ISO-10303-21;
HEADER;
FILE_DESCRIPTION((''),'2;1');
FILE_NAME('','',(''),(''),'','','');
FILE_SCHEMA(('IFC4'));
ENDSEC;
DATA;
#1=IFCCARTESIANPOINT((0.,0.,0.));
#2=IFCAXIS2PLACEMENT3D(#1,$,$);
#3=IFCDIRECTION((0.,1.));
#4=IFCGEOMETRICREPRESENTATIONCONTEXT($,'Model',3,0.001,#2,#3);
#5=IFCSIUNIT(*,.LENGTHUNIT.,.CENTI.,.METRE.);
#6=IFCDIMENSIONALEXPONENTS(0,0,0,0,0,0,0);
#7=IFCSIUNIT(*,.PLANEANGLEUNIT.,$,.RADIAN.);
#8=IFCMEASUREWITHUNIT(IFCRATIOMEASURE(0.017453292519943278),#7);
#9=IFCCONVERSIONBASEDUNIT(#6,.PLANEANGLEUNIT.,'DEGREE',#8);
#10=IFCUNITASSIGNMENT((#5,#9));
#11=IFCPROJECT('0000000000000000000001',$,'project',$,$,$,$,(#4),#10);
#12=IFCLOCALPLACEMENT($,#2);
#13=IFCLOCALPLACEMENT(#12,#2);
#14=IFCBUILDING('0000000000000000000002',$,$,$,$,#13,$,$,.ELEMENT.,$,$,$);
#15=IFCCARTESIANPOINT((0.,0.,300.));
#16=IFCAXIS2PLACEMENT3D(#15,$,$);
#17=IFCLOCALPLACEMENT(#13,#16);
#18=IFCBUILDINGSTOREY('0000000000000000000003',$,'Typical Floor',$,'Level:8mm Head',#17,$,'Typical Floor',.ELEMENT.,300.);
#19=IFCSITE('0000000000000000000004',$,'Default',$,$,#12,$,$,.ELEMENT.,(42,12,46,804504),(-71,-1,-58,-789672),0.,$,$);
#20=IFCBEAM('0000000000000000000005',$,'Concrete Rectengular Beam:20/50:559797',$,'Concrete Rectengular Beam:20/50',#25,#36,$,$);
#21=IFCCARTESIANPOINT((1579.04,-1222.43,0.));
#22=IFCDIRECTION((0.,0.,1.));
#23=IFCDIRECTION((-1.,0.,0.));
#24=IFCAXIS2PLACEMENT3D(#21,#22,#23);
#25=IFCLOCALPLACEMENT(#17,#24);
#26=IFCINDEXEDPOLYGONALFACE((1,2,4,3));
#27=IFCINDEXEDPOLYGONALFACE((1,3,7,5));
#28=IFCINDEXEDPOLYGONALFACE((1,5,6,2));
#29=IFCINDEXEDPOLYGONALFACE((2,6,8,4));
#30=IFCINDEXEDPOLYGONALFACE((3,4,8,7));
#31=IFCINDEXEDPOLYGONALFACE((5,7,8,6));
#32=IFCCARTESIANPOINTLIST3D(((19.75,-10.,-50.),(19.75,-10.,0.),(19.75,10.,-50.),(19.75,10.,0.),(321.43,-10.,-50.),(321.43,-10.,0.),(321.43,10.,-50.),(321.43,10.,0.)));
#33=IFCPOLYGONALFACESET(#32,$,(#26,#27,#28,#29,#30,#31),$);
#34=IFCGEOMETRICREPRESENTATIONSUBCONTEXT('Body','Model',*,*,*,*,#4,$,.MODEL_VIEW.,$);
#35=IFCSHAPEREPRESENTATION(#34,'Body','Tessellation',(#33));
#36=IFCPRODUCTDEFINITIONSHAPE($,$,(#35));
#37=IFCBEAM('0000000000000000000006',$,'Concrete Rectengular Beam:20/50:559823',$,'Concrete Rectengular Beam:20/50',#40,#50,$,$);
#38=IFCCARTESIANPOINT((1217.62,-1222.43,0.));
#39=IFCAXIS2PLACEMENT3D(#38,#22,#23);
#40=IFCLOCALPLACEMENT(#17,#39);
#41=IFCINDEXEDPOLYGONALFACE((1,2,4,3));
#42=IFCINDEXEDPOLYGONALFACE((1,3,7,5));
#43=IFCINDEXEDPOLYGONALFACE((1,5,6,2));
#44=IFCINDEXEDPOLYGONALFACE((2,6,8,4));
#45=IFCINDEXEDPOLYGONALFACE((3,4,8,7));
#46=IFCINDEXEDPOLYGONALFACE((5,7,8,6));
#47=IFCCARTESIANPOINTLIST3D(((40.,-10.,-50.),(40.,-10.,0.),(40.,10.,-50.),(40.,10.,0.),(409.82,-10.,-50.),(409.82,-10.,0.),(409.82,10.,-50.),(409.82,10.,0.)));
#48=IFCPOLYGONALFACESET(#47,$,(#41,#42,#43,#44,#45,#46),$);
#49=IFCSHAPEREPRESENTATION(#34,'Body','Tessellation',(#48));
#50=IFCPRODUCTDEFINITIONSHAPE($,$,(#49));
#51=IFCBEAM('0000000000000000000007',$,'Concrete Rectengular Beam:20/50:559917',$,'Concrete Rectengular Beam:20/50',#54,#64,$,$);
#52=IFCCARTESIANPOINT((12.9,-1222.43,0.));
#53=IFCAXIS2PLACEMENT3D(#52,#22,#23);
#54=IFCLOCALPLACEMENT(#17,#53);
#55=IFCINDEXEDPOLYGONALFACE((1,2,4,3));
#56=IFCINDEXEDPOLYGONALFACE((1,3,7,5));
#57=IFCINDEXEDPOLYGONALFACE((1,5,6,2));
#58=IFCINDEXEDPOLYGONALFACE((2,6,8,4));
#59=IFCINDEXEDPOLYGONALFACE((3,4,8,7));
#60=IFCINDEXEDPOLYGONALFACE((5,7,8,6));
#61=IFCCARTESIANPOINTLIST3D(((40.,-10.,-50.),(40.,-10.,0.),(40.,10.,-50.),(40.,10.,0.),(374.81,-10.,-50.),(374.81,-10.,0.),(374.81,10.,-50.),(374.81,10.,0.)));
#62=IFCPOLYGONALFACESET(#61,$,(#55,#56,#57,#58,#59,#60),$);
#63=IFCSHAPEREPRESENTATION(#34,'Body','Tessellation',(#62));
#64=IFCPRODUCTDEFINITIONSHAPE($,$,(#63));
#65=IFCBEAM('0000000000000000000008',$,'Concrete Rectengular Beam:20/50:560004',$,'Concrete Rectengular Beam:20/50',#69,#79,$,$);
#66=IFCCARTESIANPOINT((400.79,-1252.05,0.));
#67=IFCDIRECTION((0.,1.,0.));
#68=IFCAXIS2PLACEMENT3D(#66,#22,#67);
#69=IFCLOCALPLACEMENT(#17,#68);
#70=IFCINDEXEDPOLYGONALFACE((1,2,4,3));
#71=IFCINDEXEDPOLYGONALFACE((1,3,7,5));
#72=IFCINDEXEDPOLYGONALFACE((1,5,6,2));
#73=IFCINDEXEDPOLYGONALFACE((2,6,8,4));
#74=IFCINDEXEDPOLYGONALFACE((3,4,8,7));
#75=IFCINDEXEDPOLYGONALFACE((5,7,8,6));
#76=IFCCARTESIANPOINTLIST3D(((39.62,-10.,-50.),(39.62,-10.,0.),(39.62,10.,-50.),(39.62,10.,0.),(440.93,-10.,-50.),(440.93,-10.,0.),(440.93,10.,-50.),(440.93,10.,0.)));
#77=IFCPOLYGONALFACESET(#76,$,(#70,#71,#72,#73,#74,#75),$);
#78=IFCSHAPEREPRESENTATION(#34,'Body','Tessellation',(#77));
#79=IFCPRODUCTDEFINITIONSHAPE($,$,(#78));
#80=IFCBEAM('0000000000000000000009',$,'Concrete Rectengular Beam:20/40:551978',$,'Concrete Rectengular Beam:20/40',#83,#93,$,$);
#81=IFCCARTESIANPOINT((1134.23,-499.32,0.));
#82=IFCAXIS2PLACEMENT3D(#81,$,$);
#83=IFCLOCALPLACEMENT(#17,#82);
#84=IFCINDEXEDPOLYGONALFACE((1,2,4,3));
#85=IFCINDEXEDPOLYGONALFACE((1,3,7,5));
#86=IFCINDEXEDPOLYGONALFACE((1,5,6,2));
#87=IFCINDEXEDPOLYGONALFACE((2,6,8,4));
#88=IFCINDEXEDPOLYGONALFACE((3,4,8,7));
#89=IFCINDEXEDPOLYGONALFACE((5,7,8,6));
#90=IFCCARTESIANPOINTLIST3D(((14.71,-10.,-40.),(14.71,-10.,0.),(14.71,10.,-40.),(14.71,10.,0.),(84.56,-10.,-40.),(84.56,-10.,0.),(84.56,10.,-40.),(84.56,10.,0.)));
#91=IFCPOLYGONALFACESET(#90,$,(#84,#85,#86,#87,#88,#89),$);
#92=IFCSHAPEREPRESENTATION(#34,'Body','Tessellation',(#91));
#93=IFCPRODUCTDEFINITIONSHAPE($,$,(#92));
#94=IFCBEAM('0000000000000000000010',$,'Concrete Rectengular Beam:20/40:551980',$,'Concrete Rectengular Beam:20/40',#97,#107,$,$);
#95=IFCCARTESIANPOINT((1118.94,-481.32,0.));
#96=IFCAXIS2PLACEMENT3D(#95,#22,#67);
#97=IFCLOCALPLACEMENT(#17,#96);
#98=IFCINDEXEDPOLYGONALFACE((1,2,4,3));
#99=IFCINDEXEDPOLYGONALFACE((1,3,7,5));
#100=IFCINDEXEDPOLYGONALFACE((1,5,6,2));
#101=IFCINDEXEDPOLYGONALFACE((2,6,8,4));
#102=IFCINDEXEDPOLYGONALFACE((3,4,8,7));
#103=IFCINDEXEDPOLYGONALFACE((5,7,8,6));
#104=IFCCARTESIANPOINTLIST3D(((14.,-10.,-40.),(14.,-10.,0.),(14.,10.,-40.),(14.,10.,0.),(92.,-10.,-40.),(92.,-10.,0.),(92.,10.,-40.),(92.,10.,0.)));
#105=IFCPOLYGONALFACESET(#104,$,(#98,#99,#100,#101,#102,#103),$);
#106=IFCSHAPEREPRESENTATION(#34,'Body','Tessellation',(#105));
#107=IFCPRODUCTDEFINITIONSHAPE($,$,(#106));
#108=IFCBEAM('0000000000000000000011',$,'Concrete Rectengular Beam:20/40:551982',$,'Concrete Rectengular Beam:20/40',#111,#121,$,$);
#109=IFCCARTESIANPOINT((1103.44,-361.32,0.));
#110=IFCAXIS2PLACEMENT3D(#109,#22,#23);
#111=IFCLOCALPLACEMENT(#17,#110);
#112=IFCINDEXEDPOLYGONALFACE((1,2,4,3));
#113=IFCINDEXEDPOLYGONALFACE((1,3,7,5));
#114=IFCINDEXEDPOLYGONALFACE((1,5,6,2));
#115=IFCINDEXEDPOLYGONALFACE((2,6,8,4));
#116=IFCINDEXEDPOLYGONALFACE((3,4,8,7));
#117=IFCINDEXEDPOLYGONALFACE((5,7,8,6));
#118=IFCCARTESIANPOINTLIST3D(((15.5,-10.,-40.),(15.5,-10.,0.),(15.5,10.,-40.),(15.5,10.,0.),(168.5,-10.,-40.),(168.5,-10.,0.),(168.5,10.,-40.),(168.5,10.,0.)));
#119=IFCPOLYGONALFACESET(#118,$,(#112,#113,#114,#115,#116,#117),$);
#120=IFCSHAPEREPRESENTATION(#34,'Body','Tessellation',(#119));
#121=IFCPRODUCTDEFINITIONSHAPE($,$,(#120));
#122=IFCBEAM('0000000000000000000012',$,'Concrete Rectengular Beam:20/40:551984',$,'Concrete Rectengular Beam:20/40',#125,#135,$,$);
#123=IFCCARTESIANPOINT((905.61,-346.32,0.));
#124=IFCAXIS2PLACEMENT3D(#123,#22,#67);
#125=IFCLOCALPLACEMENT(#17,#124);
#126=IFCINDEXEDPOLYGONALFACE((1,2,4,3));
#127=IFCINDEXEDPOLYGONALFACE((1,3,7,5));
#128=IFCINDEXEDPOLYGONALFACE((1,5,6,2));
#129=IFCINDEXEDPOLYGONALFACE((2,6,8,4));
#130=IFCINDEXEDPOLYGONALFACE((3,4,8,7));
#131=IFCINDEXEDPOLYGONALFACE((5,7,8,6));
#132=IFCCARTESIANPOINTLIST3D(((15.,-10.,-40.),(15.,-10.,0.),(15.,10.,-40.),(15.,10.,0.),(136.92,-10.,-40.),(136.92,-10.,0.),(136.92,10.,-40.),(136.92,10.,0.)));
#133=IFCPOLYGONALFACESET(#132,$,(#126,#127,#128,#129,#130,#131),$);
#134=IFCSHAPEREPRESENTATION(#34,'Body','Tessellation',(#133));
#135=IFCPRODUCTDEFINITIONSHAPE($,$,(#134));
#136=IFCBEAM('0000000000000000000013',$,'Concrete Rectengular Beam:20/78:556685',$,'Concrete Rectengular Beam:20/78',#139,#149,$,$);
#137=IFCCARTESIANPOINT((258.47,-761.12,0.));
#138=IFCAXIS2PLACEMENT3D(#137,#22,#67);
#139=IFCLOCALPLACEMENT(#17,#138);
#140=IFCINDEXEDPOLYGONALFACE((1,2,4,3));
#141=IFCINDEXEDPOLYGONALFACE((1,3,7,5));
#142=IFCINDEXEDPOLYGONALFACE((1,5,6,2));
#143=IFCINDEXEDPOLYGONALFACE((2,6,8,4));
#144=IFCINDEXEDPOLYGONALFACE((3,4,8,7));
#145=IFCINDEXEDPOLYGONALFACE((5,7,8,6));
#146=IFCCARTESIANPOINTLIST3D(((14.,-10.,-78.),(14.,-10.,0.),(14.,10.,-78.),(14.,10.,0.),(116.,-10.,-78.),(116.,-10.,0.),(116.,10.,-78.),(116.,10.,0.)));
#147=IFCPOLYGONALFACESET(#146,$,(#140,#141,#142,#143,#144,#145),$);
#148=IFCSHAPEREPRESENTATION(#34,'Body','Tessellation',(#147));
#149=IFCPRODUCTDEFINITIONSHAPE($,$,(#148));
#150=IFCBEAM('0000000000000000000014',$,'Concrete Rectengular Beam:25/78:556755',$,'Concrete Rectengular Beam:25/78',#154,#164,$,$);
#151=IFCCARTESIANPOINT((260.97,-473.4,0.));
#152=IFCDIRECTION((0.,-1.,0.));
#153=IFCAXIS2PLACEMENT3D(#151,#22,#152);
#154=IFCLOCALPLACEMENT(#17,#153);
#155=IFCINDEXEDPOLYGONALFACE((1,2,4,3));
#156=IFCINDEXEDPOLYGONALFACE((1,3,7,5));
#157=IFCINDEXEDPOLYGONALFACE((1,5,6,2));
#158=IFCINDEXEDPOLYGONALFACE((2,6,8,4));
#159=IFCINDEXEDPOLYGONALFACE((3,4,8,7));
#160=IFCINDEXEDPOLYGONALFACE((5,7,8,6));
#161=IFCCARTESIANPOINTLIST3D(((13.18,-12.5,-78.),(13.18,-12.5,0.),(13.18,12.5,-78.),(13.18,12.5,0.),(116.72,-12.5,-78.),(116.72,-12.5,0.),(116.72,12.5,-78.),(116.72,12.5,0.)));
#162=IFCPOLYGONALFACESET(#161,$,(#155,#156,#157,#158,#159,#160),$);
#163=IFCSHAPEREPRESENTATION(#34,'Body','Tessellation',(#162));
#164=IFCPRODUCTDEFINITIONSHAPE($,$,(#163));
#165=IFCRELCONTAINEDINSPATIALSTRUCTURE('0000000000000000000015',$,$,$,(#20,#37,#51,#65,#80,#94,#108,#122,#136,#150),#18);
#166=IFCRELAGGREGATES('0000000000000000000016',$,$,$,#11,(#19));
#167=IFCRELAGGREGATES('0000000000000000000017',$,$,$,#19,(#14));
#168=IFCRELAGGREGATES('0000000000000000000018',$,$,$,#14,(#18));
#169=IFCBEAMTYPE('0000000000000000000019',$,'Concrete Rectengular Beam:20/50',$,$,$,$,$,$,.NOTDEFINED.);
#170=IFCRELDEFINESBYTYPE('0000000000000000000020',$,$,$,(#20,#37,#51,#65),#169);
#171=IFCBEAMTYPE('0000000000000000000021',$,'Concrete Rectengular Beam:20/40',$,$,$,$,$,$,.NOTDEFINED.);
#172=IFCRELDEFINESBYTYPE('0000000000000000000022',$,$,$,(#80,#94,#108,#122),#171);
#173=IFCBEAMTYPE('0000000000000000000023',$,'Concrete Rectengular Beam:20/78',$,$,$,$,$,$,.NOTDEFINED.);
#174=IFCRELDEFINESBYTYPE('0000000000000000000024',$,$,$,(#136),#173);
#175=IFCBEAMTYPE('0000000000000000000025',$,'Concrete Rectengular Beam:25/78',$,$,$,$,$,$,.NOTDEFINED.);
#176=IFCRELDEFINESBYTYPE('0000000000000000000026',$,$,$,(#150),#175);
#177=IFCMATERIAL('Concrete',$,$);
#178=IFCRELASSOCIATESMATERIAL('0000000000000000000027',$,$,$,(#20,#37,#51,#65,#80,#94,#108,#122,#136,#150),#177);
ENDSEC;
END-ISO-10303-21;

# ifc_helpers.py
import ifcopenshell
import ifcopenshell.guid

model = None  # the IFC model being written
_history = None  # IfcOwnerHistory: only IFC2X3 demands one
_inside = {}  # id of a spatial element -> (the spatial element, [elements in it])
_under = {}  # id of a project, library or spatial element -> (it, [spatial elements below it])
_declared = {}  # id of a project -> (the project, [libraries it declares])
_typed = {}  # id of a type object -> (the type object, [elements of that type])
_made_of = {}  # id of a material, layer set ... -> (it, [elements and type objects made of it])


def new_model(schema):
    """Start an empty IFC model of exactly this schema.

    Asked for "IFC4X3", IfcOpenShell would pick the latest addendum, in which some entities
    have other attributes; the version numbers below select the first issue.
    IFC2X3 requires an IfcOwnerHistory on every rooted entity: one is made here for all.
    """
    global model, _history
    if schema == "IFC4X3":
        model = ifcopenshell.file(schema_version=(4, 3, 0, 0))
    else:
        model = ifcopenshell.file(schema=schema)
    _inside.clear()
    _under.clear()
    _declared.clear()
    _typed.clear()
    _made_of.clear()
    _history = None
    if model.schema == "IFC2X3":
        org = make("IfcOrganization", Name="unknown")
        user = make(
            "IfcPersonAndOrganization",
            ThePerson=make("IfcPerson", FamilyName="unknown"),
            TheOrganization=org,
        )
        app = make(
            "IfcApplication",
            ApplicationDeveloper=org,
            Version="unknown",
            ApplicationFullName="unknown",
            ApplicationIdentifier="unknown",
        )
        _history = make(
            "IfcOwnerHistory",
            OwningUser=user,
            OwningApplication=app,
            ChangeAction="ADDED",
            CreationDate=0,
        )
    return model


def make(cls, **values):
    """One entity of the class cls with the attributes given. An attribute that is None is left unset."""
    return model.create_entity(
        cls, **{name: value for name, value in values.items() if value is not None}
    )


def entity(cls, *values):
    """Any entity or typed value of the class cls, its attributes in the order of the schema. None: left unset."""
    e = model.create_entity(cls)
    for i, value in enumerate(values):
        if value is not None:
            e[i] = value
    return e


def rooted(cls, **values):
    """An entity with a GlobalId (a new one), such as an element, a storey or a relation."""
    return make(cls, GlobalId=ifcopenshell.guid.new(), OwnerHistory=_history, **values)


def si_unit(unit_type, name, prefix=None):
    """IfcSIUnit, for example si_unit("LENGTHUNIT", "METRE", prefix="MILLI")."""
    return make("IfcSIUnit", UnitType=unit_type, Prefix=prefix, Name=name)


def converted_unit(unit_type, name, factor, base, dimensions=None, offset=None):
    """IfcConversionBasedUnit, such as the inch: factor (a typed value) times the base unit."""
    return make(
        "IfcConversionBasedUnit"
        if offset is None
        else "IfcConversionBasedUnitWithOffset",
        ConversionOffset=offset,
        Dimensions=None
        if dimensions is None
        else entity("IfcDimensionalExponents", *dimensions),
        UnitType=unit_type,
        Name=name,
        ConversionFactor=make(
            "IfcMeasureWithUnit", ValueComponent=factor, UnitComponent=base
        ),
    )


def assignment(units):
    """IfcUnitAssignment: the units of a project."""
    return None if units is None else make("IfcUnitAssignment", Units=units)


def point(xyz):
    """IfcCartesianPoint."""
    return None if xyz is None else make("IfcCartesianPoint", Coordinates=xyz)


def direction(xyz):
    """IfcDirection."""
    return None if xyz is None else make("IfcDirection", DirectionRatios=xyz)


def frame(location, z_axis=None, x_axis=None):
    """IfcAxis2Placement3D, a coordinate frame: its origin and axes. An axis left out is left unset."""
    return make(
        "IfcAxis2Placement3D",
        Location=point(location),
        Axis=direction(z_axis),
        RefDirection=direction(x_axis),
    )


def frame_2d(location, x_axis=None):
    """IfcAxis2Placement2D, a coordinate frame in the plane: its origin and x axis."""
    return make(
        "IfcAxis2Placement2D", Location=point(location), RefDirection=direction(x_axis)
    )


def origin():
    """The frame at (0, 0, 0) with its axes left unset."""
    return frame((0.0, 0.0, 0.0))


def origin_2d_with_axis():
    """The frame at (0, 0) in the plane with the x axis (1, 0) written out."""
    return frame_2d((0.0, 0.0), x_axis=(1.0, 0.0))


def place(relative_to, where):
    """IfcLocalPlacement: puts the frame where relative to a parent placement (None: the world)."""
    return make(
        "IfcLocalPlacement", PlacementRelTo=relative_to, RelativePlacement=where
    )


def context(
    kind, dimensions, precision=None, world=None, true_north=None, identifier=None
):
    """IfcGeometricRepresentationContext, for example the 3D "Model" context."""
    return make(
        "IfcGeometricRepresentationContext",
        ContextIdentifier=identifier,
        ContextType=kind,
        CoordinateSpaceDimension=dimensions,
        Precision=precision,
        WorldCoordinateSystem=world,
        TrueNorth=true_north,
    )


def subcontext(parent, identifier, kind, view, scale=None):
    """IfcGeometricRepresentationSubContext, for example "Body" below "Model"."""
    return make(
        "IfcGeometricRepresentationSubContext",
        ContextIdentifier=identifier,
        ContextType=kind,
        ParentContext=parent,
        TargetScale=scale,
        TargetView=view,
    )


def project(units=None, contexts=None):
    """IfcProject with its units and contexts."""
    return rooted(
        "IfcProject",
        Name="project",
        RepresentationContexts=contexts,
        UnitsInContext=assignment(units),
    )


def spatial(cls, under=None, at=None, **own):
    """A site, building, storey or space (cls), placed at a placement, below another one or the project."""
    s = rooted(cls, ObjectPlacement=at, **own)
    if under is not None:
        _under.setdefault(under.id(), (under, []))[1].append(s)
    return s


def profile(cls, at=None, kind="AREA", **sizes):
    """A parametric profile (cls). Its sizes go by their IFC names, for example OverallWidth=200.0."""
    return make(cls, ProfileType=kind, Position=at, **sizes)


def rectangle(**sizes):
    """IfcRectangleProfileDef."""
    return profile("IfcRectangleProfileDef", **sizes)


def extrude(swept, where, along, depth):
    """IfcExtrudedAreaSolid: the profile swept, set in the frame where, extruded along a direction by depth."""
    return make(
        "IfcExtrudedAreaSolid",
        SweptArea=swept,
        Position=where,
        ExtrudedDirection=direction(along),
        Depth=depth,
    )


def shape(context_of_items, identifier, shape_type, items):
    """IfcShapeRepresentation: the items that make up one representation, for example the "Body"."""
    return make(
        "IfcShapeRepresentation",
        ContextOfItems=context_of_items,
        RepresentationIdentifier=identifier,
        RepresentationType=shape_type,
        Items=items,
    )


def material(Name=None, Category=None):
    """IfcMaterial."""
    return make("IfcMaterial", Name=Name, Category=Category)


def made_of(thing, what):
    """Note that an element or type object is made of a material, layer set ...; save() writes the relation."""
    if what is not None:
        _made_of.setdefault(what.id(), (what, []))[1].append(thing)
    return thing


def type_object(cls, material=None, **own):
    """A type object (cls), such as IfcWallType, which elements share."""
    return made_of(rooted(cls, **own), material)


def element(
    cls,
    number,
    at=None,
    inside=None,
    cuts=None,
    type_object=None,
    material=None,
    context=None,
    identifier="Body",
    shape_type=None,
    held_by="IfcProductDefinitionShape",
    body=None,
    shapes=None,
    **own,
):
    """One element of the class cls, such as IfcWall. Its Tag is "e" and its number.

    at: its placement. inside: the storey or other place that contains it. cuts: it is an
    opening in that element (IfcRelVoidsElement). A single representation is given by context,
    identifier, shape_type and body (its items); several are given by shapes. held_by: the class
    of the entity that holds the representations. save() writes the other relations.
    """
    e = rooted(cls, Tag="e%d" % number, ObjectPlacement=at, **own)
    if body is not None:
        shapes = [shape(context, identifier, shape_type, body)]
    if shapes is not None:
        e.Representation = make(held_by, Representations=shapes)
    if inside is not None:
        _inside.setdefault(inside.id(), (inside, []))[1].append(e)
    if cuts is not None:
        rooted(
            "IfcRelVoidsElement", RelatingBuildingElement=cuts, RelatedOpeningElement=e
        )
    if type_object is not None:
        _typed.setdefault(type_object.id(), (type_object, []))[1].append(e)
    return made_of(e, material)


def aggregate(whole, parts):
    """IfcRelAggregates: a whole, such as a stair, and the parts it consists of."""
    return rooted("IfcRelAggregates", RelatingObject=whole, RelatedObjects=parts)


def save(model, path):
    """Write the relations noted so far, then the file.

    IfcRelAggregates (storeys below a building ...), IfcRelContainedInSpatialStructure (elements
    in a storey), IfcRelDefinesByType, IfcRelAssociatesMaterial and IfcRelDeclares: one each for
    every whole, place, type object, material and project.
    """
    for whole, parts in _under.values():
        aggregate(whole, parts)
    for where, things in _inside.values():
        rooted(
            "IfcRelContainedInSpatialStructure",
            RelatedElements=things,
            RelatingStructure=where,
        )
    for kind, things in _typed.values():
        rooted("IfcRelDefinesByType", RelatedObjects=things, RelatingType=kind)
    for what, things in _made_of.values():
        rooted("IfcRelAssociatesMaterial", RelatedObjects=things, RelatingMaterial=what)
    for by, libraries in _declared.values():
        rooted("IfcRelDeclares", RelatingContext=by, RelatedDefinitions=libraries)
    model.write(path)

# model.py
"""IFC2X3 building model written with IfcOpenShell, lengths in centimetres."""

from ifc_helpers import new_model, entity, si_unit, converted_unit, direction, frame, frame_2d, origin, origin_2d_with_axis, place, context, subcontext, project, spatial, rectangle, extrude, material, type_object, element, save


model = new_model("IFC2X3")

# Units and contexts
model_context = context("Model", 3, precision=0.001, world=origin(), true_north=direction((0.0, 1.0)))
body_context = subcontext(model_context, "Body", "Model", "MODEL_VIEW")
ifc_project = project(units=[si_unit("LENGTHUNIT", "METRE", prefix="CENTI"), converted_unit("PLANEANGLEUNIT", "DEGREE", entity("IfcRatioMeasure", 0.017453292519943278), si_unit("PLANEANGLEUNIT", "RADIAN"), dimensions=[0, 0, 0, 0, 0, 0, 0])], contexts=[model_context])

# Site, building, storey
site_placement = place(None, origin())
site = spatial("IfcSite", under=ifc_project, at=site_placement, Name="Default", CompositionType="ELEMENT", RefLatitude=(42, 12, 46, 804504), RefLongitude=(-71, -1, -58, -789672), RefElevation=0.0)
building_placement = place(site_placement, origin())
building = spatial("IfcBuilding", under=site, at=building_placement, CompositionType="ELEMENT")
storey_placement = place(building_placement, frame((0.0, 0.0, 300.0)))
storey = spatial("IfcBuildingStorey", under=building, at=storey_placement, Name="Typical Floor", ObjectType="Level:8mm Head", LongName="Typical Floor", CompositionType="ELEMENT", Elevation=300.0)

# Beams
ifc_material = material(Name="Concrete")
beam_type_1 = type_object("IfcBeamType", Name="Concrete Rectengular Beam:20/50", PredefinedType="NOTDEFINED")
beam_1_placement = place(storey_placement, frame((1579.04, -1222.43, 0.0), z_axis=(0.0, 0.0, 1.0), x_axis=(-1.0, 0.0, 0.0)))
element("IfcBeam", 1, at=beam_1_placement, inside=storey, type_object=beam_type_1, material=ifc_material, Name="Concrete Rectengular Beam:20/50:559797", ObjectType="Concrete Rectengular Beam:20/50", context=body_context, shape_type="SweptSolid", body=[
    extrude(rectangle(XDim=50.0, YDim=20.0, at=frame_2d((0.0, 0.0), x_axis=(1.0, 0.0))), frame((19.75, 0.0, -25.0), z_axis=(1.0, 0.0, 0.0), x_axis=(0.0, 0.0, -1.0)), (0.0, 0.0, 1.0), 301.68),
])
beam_2_placement = place(storey_placement, frame((1217.62, -1222.43, 0.0), z_axis=(0.0, 0.0, 1.0), x_axis=(-1.0, 0.0, 0.0)))
element("IfcBeam", 2, at=beam_2_placement, inside=storey, type_object=beam_type_1, material=ifc_material, Name="Concrete Rectengular Beam:20/50:559823", ObjectType="Concrete Rectengular Beam:20/50", context=body_context, shape_type="SweptSolid", body=[
    extrude(rectangle(XDim=50.0, YDim=20.0, at=frame_2d((0.0, 0.0), x_axis=(1.0, 0.0))), frame((40.0, 0.0, -25.0), z_axis=(1.0, 0.0, 0.0), x_axis=(0.0, 0.0, -1.0)), (0.0, 0.0, 1.0), 369.82),
])
beam_3_placement = place(storey_placement, frame((12.9, -1222.43, 0.0), z_axis=(0.0, 0.0, 1.0), x_axis=(-1.0, 0.0, 0.0)))
element("IfcBeam", 3, at=beam_3_placement, inside=storey, type_object=beam_type_1, material=ifc_material, Name="Concrete Rectengular Beam:20/50:559917", ObjectType="Concrete Rectengular Beam:20/50", context=body_context, shape_type="SweptSolid", body=[
    extrude(rectangle(XDim=50.0, YDim=20.0, at=frame_2d((0.0, 0.0), x_axis=(1.0, 0.0))), frame((40.0, 0.0, -25.0), z_axis=(1.0, 0.0, 0.0), x_axis=(0.0, 0.0, -1.0)), (0.0, 0.0, 1.0), 334.81),
])
beam_4_placement = place(storey_placement, frame((400.79, -1252.05, 0.0), z_axis=(0.0, 0.0, 1.0), x_axis=(0.0, 1.0, 0.0)))
element("IfcBeam", 4, at=beam_4_placement, inside=storey, type_object=beam_type_1, material=ifc_material, Name="Concrete Rectengular Beam:20/50:560004", ObjectType="Concrete Rectengular Beam:20/50", context=body_context, shape_type="SweptSolid", body=[
    extrude(rectangle(XDim=50.0, YDim=20.0, at=frame_2d((0.0, 0.0), x_axis=(1.0, 0.0))), frame((39.62, 0.0, -25.0), z_axis=(1.0, 0.0, 0.0), x_axis=(0.0, 0.0, -1.0)), (0.0, 0.0, 1.0), 401.31),
])
beam_type_2 = type_object("IfcBeamType", Name="Concrete Rectengular Beam:20/40", PredefinedType="NOTDEFINED")
beam_5_placement = place(storey_placement, frame((1134.23, -499.32, 0.0)))
element("IfcBeam", 5, at=beam_5_placement, inside=storey, type_object=beam_type_2, material=ifc_material, Name="Concrete Rectengular Beam:20/40:551978", ObjectType="Concrete Rectengular Beam:20/40", context=body_context, shape_type="SweptSolid", body=[
    extrude(rectangle(XDim=40.0, YDim=20.0, at=frame_2d((0.0, 0.0), x_axis=(1.0, 0.0))), frame((14.71, 0.0, -20.0), z_axis=(1.0, 0.0, 0.0), x_axis=(0.0, 0.0, -1.0)), (0.0, 0.0, 1.0), 69.85),
])
beam_6_placement = place(storey_placement, frame((1118.94, -481.32, 0.0), z_axis=(0.0, 0.0, 1.0), x_axis=(0.0, 1.0, 0.0)))
element("IfcBeam", 6, at=beam_6_placement, inside=storey, type_object=beam_type_2, material=ifc_material, Name="Concrete Rectengular Beam:20/40:551980", ObjectType="Concrete Rectengular Beam:20/40", context=body_context, shape_type="SweptSolid", body=[
    extrude(rectangle(XDim=40.0, YDim=20.0, at=frame_2d((0.0, 0.0), x_axis=(1.0, 0.0))), frame((14.0, 0.0, -20.0), z_axis=(1.0, 0.0, 0.0), x_axis=(0.0, 0.0, -1.0)), (0.0, 0.0, 1.0), 78.0),
])
beam_7_placement = place(storey_placement, frame((1103.44, -361.32, 0.0), z_axis=(0.0, 0.0, 1.0), x_axis=(-1.0, 0.0, 0.0)))
element("IfcBeam", 7, at=beam_7_placement, inside=storey, type_object=beam_type_2, material=ifc_material, Name="Concrete Rectengular Beam:20/40:551982", ObjectType="Concrete Rectengular Beam:20/40", context=body_context, shape_type="SweptSolid", body=[
    extrude(rectangle(XDim=40.0, YDim=20.0, at=frame_2d((0.0, 0.0), x_axis=(1.0, 0.0))), frame((15.5, 0.0, -20.0), z_axis=(1.0, 0.0, 0.0), x_axis=(0.0, 0.0, -1.0)), (0.0, 0.0, 1.0), 153.0),
])
beam_8_placement = place(storey_placement, frame((905.61, -346.32, 0.0), z_axis=(0.0, 0.0, 1.0), x_axis=(0.0, 1.0, 0.0)))
element("IfcBeam", 8, at=beam_8_placement, inside=storey, type_object=beam_type_2, material=ifc_material, Name="Concrete Rectengular Beam:20/40:551984", ObjectType="Concrete Rectengular Beam:20/40", context=body_context, shape_type="SweptSolid", body=[
    extrude(rectangle(XDim=40.0, YDim=20.0, at=origin_2d_with_axis()), frame((15.0, 0.0, -20.0), z_axis=(1.0, 0.0, 0.0), x_axis=(0.0, 0.0, -1.0)), (0.0, 0.0, 1.0), 121.92),
])
beam_type_3 = type_object("IfcBeamType", Name="Concrete Rectengular Beam:20/78", PredefinedType="NOTDEFINED")
beam_9_placement = place(storey_placement, frame((258.47, -761.12, 0.0), z_axis=(0.0, 0.0, 1.0), x_axis=(0.0, 1.0, 0.0)))
element("IfcBeam", 9, at=beam_9_placement, inside=storey, type_object=beam_type_3, material=ifc_material, Name="Concrete Rectengular Beam:20/78:556685", ObjectType="Concrete Rectengular Beam:20/78", context=body_context, shape_type="SweptSolid", body=[
    extrude(rectangle(XDim=78.0, YDim=20.0, at=frame_2d((0.0, 0.0), x_axis=(1.0, 0.0))), frame((14.0, 0.0, -39.0), z_axis=(1.0, 0.0, 0.0), x_axis=(0.0, 0.0, -1.0)), (0.0, 0.0, 1.0), 102.0),
])
beam_type_4 = type_object("IfcBeamType", Name="Concrete Rectengular Beam:25/78", PredefinedType="NOTDEFINED")
beam_10_placement = place(storey_placement, frame((260.97, -473.4, 0.0), z_axis=(0.0, 0.0, 1.0), x_axis=(0.0, -1.0, 0.0)))
element("IfcBeam", 10, at=beam_10_placement, inside=storey, type_object=beam_type_4, material=ifc_material, Name="Concrete Rectengular Beam:25/78:556755", ObjectType="Concrete Rectengular Beam:25/78", context=body_context, shape_type="SweptSolid", body=[
    extrude(rectangle(XDim=78.0, YDim=25.0, at=frame_2d((0.0, 0.0), x_axis=(1.0, 0.0))), frame((13.18, 0.0, -39.0), z_axis=(1.0, 0.0, 0.0), x_axis=(0.0, 0.0, -1.0)), (0.0, 0.0, 1.0), 103.54),
])

save(model, "model.ifc")
